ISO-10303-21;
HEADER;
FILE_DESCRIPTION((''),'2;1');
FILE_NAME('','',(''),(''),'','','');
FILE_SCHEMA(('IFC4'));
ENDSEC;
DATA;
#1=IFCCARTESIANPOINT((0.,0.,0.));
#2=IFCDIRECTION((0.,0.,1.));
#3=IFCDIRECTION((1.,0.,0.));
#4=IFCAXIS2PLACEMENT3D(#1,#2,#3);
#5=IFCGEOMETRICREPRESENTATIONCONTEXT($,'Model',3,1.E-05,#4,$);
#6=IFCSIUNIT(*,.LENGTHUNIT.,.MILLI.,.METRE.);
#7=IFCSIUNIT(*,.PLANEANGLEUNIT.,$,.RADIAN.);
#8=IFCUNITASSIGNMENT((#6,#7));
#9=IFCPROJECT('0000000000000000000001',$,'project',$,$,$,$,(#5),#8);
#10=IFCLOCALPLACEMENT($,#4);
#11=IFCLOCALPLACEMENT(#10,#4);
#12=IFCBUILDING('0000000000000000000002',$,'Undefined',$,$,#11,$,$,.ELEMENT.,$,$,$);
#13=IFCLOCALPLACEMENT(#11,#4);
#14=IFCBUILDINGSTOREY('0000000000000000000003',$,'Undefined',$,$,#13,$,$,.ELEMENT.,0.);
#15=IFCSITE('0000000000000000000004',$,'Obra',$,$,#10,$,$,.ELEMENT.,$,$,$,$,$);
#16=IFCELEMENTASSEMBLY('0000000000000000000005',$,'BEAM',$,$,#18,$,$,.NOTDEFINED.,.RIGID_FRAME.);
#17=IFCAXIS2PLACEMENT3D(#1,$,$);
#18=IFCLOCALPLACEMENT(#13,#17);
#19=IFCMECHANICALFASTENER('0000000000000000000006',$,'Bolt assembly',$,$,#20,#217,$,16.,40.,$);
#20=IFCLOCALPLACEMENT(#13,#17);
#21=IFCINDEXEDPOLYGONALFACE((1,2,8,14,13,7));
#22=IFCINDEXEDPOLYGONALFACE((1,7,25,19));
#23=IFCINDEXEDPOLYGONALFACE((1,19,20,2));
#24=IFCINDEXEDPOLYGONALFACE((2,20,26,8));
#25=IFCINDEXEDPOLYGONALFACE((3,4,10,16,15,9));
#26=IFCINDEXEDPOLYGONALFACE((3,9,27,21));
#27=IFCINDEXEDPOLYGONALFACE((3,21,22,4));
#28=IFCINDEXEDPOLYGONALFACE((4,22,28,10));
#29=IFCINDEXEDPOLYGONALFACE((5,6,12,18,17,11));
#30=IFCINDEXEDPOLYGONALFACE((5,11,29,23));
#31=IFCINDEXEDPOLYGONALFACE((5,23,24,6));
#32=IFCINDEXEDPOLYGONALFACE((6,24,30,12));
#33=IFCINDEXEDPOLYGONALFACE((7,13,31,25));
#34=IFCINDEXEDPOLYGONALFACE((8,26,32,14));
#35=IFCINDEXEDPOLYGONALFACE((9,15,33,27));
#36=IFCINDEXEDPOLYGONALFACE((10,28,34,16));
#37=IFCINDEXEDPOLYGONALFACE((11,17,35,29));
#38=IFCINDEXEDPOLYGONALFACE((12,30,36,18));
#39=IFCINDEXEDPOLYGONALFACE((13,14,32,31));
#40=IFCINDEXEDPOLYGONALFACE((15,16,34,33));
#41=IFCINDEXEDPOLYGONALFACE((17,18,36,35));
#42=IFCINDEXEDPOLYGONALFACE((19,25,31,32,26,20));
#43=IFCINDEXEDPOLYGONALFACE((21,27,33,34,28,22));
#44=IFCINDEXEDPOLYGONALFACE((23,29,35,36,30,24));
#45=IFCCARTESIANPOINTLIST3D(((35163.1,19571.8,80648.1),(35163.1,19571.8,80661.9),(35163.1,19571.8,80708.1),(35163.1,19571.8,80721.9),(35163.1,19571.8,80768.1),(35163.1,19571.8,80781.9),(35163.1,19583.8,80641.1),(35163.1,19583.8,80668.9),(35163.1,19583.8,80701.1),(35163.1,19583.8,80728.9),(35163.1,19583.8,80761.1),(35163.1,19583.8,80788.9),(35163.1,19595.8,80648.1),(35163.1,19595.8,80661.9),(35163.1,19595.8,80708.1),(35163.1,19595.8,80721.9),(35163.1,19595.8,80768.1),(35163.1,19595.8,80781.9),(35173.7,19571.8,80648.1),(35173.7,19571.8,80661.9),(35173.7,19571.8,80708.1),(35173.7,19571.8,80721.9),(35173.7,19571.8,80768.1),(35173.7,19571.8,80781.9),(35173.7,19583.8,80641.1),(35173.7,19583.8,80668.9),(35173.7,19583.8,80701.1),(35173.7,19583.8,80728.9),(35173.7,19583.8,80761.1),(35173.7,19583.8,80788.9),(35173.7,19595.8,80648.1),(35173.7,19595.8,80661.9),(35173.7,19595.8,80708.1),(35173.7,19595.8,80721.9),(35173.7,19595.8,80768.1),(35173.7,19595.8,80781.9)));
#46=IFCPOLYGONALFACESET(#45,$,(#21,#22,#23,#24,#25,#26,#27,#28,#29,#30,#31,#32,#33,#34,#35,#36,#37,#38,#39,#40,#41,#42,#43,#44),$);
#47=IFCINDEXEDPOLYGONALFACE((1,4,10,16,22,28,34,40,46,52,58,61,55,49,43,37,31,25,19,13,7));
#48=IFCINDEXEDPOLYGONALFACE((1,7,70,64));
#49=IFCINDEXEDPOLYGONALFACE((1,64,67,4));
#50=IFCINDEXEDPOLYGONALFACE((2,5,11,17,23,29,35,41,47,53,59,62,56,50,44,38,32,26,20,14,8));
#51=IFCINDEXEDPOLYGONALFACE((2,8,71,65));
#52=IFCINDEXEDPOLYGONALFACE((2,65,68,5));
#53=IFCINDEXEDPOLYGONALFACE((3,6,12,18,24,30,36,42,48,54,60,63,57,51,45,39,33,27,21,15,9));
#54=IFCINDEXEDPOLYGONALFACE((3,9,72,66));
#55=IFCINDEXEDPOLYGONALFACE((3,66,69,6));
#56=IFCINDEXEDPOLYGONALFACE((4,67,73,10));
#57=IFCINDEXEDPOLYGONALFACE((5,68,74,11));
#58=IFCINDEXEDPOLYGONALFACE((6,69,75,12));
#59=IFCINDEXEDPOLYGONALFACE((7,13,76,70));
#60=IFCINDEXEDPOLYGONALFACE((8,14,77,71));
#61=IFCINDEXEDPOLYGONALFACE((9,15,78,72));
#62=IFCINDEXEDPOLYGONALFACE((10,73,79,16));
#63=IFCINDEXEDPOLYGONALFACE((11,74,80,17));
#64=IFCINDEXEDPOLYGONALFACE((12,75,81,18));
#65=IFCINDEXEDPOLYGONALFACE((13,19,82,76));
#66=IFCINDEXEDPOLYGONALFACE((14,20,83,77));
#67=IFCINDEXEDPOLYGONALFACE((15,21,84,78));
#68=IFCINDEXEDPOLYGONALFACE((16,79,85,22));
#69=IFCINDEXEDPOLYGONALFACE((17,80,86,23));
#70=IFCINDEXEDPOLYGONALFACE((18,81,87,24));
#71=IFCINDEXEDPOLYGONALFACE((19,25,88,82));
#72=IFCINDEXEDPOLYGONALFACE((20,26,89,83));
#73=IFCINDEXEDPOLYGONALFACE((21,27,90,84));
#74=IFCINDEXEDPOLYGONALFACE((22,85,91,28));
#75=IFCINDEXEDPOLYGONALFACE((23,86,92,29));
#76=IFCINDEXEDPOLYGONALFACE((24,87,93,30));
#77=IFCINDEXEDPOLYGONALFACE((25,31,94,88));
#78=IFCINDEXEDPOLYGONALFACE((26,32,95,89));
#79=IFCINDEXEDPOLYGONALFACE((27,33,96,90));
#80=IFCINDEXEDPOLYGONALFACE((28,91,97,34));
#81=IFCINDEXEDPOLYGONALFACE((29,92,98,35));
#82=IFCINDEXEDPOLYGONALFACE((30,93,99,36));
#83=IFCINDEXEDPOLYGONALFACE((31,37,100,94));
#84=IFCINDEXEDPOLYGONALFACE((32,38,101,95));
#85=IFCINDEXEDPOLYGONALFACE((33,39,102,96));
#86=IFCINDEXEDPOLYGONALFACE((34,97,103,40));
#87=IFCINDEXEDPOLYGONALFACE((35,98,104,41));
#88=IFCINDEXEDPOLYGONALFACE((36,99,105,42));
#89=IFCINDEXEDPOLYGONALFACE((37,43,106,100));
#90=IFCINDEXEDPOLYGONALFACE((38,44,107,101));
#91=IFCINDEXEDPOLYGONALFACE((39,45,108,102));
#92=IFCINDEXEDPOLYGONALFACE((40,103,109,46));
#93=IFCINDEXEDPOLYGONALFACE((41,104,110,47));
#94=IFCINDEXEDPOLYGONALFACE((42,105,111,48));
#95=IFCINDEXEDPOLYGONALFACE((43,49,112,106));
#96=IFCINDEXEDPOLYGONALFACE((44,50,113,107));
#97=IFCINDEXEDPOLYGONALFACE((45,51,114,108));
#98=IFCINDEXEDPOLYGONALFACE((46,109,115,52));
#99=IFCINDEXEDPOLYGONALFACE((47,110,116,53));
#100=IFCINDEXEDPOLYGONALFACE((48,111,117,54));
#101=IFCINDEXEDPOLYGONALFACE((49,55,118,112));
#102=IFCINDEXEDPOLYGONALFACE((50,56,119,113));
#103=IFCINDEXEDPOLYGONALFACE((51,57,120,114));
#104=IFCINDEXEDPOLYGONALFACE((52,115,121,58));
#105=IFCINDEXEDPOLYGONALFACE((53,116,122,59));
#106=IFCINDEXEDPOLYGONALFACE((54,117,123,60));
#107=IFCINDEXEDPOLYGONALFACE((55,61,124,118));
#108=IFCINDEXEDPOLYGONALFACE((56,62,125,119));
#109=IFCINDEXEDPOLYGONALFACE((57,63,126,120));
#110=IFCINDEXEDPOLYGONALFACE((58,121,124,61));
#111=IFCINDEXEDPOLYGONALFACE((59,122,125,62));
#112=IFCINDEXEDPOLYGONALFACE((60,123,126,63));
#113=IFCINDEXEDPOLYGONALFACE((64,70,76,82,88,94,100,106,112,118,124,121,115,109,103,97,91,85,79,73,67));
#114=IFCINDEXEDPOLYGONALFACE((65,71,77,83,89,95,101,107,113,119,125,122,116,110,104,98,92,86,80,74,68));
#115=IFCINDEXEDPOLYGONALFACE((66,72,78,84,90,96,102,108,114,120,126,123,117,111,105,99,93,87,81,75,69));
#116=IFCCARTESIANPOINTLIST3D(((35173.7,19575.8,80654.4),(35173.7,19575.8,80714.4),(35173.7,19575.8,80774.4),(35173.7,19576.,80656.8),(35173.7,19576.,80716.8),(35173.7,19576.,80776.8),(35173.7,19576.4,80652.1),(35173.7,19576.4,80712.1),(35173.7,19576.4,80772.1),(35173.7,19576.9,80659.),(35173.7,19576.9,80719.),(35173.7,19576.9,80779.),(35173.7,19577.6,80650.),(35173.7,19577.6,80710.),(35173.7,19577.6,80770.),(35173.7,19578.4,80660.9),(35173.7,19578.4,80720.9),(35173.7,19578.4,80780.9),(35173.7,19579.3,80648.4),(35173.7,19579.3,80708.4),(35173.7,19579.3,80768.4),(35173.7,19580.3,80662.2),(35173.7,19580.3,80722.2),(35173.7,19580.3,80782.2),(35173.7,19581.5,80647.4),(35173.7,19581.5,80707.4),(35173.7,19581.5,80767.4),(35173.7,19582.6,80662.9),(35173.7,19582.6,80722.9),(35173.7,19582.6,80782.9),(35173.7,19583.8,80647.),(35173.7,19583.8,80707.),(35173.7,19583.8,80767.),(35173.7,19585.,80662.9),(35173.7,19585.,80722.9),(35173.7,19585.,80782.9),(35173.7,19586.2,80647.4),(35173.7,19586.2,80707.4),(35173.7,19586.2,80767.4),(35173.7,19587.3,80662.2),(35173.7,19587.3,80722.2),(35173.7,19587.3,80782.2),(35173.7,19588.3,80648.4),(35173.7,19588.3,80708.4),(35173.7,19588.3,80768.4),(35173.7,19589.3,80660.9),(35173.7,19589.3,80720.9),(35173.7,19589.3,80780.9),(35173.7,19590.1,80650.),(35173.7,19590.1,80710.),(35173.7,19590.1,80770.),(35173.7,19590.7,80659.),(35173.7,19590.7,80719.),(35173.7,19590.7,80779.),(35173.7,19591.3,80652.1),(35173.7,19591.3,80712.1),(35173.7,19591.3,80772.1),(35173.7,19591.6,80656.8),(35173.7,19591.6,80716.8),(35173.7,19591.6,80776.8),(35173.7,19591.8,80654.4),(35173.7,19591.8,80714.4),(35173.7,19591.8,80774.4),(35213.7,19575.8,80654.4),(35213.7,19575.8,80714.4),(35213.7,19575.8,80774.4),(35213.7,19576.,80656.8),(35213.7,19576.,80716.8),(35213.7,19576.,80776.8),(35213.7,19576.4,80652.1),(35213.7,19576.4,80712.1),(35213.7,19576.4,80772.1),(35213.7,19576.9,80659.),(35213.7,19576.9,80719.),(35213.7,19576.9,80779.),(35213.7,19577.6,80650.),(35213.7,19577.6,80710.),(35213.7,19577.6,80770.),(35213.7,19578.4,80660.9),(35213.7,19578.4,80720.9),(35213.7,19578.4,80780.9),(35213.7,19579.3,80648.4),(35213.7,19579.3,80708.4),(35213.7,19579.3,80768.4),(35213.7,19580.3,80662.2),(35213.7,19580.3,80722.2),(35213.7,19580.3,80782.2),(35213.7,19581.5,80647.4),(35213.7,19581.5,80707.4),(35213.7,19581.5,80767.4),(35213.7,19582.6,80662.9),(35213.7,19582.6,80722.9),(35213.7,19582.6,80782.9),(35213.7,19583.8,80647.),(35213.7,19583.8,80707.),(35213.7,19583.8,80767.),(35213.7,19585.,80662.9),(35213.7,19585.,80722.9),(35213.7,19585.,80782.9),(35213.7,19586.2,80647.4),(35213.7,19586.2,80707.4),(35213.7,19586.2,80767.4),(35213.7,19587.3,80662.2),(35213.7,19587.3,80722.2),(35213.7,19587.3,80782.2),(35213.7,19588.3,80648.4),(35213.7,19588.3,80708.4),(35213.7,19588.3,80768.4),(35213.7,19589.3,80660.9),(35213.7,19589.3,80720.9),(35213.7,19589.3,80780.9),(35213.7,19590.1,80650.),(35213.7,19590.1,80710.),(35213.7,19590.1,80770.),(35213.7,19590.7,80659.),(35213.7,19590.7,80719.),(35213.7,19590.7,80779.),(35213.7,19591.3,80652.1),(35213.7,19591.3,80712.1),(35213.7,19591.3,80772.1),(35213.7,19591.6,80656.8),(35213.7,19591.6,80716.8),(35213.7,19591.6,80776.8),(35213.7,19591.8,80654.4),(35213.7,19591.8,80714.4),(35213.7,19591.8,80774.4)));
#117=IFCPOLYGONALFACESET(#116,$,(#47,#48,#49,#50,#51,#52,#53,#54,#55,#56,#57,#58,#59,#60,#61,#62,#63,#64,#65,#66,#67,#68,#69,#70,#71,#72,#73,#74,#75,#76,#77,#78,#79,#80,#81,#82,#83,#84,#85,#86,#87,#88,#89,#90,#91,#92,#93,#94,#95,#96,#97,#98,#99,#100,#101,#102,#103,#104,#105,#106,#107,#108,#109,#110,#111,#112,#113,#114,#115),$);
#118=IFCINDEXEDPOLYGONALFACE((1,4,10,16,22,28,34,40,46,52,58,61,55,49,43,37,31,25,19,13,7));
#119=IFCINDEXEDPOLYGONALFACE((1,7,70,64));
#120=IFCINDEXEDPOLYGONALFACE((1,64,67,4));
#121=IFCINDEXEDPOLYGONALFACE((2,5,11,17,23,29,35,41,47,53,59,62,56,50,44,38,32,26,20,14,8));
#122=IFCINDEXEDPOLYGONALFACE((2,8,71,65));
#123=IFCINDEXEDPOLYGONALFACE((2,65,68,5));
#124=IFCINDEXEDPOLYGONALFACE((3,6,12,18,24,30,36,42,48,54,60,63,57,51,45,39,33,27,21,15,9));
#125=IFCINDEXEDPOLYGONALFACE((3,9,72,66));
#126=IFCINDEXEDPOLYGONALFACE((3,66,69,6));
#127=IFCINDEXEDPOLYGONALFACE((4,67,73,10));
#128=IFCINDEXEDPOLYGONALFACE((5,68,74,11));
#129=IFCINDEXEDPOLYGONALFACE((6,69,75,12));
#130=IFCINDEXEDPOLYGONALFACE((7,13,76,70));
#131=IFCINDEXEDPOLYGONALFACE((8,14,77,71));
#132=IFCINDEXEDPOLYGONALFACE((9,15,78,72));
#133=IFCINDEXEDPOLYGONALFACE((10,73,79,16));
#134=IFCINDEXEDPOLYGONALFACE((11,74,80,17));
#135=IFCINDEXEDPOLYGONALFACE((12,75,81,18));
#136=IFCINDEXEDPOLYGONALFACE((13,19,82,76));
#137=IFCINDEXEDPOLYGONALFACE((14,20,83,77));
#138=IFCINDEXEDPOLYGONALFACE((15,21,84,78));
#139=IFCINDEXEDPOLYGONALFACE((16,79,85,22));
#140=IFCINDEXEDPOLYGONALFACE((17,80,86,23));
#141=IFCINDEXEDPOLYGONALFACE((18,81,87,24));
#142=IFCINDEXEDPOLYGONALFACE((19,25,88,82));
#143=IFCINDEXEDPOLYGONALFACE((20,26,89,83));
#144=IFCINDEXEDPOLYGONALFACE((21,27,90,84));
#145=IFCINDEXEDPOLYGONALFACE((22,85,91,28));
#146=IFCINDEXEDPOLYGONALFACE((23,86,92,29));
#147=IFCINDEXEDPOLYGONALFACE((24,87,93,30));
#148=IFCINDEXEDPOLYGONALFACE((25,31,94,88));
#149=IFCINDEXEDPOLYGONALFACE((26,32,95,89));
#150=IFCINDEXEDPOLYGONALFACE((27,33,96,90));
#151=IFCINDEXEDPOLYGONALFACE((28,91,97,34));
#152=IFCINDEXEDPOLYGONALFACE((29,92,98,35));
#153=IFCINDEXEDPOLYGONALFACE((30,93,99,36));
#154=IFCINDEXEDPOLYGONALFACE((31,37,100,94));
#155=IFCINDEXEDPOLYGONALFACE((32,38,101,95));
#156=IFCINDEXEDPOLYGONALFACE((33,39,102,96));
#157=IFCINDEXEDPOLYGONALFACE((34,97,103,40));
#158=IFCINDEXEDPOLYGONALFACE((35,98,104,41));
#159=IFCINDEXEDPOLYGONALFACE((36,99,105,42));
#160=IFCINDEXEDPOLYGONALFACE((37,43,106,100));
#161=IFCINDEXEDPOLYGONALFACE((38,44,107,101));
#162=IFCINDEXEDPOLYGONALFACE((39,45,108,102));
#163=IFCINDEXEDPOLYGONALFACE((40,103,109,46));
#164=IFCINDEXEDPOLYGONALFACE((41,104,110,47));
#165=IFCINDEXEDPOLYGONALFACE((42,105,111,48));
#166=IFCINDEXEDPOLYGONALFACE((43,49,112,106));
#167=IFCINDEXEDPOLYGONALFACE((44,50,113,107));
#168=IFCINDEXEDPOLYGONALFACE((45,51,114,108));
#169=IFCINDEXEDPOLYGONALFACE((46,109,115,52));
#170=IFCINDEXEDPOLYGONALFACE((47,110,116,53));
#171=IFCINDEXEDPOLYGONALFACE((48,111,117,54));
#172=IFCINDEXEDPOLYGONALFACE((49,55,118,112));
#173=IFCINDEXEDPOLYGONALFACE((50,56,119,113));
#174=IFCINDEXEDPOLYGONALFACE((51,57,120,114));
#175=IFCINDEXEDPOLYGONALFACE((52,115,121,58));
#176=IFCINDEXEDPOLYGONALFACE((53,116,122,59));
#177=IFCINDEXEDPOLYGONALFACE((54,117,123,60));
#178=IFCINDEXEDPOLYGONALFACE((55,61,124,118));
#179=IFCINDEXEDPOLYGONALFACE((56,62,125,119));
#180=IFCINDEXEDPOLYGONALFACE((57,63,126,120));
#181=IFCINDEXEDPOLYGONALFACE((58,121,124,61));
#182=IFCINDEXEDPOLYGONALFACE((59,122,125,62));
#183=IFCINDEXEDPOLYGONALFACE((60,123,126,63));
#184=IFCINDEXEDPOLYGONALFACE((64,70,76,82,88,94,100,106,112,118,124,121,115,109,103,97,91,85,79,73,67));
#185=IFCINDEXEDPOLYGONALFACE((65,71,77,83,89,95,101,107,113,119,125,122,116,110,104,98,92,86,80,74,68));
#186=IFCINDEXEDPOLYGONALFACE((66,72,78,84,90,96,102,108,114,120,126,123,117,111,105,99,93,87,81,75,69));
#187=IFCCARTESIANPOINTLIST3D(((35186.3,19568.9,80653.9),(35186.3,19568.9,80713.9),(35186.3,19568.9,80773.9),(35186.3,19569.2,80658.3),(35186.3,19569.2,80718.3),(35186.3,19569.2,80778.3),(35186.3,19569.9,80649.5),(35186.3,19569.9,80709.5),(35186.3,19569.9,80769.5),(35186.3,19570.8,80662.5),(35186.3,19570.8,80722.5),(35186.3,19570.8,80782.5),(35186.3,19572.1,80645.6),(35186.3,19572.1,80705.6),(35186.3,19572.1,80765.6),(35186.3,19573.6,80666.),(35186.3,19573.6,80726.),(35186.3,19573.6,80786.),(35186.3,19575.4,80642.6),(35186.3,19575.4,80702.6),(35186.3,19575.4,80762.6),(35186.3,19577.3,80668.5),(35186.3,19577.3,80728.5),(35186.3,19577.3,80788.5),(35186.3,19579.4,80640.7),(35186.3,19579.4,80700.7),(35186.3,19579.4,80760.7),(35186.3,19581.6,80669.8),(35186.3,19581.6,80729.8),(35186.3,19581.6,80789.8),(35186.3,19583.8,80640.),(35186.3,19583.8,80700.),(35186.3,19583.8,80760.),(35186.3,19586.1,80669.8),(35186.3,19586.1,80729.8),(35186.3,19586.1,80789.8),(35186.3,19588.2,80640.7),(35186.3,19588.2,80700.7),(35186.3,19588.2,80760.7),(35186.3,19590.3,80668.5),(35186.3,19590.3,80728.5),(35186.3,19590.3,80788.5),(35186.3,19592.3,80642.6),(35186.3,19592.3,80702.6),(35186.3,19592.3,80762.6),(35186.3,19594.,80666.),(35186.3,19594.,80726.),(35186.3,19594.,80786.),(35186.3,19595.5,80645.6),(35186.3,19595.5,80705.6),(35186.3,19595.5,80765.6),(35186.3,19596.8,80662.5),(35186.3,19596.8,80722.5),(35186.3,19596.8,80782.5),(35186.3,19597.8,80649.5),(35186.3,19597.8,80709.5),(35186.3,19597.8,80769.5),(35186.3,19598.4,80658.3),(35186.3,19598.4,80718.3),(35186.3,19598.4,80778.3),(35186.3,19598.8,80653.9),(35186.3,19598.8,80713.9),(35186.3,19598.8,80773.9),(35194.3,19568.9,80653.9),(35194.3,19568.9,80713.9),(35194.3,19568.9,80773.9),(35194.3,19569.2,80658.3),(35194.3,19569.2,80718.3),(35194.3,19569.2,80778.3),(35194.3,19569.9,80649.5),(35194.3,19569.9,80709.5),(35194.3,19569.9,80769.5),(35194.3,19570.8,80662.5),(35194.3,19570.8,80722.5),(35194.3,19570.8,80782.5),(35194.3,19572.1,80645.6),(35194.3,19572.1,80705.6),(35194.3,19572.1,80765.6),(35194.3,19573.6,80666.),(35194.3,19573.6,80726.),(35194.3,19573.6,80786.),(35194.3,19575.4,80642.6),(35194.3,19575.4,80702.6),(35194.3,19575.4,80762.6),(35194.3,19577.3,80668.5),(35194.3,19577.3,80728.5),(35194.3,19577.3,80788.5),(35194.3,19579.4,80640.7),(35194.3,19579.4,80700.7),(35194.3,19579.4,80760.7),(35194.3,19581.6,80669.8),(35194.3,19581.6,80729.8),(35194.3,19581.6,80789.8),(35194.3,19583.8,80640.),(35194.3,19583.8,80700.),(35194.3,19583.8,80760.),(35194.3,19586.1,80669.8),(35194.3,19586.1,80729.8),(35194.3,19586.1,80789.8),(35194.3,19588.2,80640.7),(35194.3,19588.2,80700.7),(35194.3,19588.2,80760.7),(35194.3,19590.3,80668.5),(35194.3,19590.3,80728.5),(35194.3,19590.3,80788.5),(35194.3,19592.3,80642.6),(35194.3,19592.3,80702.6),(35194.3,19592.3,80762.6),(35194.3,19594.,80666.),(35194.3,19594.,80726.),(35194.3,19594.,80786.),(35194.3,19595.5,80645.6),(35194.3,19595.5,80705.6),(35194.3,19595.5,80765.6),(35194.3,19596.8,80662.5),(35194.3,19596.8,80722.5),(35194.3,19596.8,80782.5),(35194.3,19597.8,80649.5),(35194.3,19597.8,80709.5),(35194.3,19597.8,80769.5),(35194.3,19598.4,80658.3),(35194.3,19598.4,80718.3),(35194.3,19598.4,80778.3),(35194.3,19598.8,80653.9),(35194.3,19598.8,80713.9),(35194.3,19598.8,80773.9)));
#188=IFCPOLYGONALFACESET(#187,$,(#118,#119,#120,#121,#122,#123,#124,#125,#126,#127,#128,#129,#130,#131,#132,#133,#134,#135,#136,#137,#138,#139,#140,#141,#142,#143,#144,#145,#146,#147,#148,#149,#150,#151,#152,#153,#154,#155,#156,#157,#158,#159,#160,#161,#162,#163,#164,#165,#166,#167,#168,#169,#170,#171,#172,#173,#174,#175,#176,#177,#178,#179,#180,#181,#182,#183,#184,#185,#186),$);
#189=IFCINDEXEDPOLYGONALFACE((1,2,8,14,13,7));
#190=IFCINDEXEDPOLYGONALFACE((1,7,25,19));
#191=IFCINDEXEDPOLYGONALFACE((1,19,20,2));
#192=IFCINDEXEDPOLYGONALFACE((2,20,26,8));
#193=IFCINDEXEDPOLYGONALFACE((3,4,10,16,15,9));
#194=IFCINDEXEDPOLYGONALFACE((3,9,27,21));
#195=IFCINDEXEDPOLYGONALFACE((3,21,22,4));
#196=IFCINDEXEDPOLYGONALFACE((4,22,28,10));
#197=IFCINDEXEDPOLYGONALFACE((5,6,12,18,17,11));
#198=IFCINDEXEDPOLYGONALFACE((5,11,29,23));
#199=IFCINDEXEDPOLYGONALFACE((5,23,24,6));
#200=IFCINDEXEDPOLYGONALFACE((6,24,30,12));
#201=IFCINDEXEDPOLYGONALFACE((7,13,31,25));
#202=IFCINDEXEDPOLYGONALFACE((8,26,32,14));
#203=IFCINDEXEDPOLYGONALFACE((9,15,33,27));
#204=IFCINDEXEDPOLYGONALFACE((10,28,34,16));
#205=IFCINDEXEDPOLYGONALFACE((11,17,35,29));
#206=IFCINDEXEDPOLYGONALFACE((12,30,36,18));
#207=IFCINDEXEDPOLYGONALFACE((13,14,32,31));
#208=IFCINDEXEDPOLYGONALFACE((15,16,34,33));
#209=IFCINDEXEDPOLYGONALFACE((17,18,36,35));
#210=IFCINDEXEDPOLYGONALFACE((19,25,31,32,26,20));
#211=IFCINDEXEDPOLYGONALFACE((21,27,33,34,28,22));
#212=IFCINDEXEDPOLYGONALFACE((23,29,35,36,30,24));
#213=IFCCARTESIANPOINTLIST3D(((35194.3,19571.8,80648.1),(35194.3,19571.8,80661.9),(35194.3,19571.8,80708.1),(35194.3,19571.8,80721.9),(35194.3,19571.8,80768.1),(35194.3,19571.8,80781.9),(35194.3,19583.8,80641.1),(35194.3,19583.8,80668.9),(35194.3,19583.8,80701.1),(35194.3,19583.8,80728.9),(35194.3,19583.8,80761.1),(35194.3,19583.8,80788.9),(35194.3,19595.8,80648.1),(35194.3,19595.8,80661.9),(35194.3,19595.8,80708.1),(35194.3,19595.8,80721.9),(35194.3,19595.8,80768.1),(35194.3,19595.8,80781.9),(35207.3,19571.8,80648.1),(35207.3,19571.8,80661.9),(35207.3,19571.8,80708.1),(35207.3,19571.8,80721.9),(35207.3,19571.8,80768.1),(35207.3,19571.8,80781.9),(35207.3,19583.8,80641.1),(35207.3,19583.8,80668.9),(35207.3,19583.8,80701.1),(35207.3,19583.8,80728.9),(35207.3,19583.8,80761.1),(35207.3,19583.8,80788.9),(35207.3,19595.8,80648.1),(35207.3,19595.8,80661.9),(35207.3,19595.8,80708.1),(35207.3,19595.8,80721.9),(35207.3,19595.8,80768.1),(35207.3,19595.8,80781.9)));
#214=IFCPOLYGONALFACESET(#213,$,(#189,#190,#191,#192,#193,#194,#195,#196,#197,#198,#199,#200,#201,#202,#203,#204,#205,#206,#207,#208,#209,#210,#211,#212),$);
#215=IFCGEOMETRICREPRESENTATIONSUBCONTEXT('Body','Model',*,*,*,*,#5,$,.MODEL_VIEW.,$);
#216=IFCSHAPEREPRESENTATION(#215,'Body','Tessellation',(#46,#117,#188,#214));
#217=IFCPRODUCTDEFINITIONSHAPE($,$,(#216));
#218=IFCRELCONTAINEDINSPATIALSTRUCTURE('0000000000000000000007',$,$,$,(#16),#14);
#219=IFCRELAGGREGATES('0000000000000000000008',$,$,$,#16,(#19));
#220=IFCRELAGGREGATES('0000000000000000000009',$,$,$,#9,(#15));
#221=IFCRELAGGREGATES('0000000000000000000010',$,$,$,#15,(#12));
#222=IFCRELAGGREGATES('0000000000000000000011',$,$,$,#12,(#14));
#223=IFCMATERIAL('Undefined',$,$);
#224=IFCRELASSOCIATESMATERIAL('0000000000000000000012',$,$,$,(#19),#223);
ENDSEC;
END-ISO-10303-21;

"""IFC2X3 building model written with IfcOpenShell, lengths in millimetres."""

from ifc_helpers import new_model, si_unit, frame, origin_with_axes, origin_2d_with_axis, place, context, subcontext, project, spatial, polyline, circle, outline, extrude, source, transform, mapped, material, element, aggregate, save


model = new_model("IFC2X3")

# Units and contexts
model_context = context("Model", 3, precision=1e-05, world=origin_with_axes())
body_context = subcontext(model_context, "Body", "Model", "MODEL_VIEW")
ifc_project = project(units=[si_unit("LENGTHUNIT", "METRE", prefix="MILLI"), si_unit("PLANEANGLEUNIT", "RADIAN")], contexts=[model_context])

# Site, building, storey
site_placement = place(None, origin_with_axes())
site = spatial("IfcSite", under=ifc_project, at=site_placement, Name="Obra", CompositionType="ELEMENT")
building_placement = place(site_placement, origin_with_axes())
building = spatial("IfcBuilding", under=site, at=building_placement, Name="Undefined", CompositionType="ELEMENT")
storey_placement = place(building_placement, origin_with_axes())
storey = spatial("IfcBuildingStorey", under=building, at=storey_placement, Name="Undefined", CompositionType="ELEMENT", Elevation=0.0)

# Shared definitions
ifc_material_1 = material(Name="Undefined")

# Element assembly, mechanical fastener
assembly_1_placement = place(storey_placement, origin_with_axes())
assembly_1 = element("IfcElementAssembly", 1, at=assembly_1_placement, inside=storey, Name="BEAM", AssemblyPlace="NOTDEFINED", PredefinedType="RIGID_FRAME")
shared_shape_1 = source(origin_with_axes(), body_context, "Body", "SweptSolid", [
    extrude(outline(polyline([(13.9, 0.0), (6.9, 12.0), (-6.9, 12.0), (-13.9, 0.0), (-6.9, -12.0), (6.9, -12.0), (13.9, 0.0)])), frame((0.0, -19.9, 0.0), z_axis=(0.0, 1.0, 0.0), x_axis=(1.0, 0.0, 0.0)), (0.0, 0.0, 1.0), 10.6),
    extrude(circle(Radius=8.0, at=origin_2d_with_axis()), frame((0.0, -9.3, 0.0), z_axis=(0.0, 1.0, 0.0), x_axis=(1.0, 0.0, 0.0)), (0.0, 0.0, 1.0), 40.0),
    extrude(circle(Radius=15.0, at=origin_2d_with_axis()), frame((0.0, 3.3, 0.0), z_axis=(0.0, 1.0, 0.0), x_axis=(1.0, 0.0, 0.0)), (0.0, 0.0, 1.0), 8.0),
    extrude(outline(polyline([(13.9, 0.0), (6.9, 12.0), (-6.9, 12.0), (-13.9, 0.0), (-6.9, -12.0), (6.9, -12.0), (13.9, 0.0)])), frame((0.0, 11.3, 0.0), z_axis=(0.0, 1.0, 0.0), x_axis=(1.0, 0.0, 0.0)), (0.0, 0.0, 1.0), 13.0),
])
mechanical_fastener_1_placement = place(assembly_1_placement, frame((35183.0, 19633.8, 80850.0), z_axis=(0.0, -1.0, 0.0), x_axis=(0.0, 0.0, -1.0)))
mechanical_fastener_1 = element("IfcMechanicalFastener", 2, at=mechanical_fastener_1_placement, material=ifc_material_1, Name="Bolt assembly", NominalDiameter=16.0, NominalLength=40.0, context=body_context, shape_type="MappedRepresentation", body=[
    mapped(shared_shape_1, transform((75.0, 0.0, 50.0))),
    mapped(shared_shape_1, transform((135.0, 0.0, 50.0))),
    mapped(shared_shape_1, transform((195.0, 0.0, 50.0))),
])
aggregate(assembly_1, [mechanical_fastener_1])

save(model, "model.ifc")
